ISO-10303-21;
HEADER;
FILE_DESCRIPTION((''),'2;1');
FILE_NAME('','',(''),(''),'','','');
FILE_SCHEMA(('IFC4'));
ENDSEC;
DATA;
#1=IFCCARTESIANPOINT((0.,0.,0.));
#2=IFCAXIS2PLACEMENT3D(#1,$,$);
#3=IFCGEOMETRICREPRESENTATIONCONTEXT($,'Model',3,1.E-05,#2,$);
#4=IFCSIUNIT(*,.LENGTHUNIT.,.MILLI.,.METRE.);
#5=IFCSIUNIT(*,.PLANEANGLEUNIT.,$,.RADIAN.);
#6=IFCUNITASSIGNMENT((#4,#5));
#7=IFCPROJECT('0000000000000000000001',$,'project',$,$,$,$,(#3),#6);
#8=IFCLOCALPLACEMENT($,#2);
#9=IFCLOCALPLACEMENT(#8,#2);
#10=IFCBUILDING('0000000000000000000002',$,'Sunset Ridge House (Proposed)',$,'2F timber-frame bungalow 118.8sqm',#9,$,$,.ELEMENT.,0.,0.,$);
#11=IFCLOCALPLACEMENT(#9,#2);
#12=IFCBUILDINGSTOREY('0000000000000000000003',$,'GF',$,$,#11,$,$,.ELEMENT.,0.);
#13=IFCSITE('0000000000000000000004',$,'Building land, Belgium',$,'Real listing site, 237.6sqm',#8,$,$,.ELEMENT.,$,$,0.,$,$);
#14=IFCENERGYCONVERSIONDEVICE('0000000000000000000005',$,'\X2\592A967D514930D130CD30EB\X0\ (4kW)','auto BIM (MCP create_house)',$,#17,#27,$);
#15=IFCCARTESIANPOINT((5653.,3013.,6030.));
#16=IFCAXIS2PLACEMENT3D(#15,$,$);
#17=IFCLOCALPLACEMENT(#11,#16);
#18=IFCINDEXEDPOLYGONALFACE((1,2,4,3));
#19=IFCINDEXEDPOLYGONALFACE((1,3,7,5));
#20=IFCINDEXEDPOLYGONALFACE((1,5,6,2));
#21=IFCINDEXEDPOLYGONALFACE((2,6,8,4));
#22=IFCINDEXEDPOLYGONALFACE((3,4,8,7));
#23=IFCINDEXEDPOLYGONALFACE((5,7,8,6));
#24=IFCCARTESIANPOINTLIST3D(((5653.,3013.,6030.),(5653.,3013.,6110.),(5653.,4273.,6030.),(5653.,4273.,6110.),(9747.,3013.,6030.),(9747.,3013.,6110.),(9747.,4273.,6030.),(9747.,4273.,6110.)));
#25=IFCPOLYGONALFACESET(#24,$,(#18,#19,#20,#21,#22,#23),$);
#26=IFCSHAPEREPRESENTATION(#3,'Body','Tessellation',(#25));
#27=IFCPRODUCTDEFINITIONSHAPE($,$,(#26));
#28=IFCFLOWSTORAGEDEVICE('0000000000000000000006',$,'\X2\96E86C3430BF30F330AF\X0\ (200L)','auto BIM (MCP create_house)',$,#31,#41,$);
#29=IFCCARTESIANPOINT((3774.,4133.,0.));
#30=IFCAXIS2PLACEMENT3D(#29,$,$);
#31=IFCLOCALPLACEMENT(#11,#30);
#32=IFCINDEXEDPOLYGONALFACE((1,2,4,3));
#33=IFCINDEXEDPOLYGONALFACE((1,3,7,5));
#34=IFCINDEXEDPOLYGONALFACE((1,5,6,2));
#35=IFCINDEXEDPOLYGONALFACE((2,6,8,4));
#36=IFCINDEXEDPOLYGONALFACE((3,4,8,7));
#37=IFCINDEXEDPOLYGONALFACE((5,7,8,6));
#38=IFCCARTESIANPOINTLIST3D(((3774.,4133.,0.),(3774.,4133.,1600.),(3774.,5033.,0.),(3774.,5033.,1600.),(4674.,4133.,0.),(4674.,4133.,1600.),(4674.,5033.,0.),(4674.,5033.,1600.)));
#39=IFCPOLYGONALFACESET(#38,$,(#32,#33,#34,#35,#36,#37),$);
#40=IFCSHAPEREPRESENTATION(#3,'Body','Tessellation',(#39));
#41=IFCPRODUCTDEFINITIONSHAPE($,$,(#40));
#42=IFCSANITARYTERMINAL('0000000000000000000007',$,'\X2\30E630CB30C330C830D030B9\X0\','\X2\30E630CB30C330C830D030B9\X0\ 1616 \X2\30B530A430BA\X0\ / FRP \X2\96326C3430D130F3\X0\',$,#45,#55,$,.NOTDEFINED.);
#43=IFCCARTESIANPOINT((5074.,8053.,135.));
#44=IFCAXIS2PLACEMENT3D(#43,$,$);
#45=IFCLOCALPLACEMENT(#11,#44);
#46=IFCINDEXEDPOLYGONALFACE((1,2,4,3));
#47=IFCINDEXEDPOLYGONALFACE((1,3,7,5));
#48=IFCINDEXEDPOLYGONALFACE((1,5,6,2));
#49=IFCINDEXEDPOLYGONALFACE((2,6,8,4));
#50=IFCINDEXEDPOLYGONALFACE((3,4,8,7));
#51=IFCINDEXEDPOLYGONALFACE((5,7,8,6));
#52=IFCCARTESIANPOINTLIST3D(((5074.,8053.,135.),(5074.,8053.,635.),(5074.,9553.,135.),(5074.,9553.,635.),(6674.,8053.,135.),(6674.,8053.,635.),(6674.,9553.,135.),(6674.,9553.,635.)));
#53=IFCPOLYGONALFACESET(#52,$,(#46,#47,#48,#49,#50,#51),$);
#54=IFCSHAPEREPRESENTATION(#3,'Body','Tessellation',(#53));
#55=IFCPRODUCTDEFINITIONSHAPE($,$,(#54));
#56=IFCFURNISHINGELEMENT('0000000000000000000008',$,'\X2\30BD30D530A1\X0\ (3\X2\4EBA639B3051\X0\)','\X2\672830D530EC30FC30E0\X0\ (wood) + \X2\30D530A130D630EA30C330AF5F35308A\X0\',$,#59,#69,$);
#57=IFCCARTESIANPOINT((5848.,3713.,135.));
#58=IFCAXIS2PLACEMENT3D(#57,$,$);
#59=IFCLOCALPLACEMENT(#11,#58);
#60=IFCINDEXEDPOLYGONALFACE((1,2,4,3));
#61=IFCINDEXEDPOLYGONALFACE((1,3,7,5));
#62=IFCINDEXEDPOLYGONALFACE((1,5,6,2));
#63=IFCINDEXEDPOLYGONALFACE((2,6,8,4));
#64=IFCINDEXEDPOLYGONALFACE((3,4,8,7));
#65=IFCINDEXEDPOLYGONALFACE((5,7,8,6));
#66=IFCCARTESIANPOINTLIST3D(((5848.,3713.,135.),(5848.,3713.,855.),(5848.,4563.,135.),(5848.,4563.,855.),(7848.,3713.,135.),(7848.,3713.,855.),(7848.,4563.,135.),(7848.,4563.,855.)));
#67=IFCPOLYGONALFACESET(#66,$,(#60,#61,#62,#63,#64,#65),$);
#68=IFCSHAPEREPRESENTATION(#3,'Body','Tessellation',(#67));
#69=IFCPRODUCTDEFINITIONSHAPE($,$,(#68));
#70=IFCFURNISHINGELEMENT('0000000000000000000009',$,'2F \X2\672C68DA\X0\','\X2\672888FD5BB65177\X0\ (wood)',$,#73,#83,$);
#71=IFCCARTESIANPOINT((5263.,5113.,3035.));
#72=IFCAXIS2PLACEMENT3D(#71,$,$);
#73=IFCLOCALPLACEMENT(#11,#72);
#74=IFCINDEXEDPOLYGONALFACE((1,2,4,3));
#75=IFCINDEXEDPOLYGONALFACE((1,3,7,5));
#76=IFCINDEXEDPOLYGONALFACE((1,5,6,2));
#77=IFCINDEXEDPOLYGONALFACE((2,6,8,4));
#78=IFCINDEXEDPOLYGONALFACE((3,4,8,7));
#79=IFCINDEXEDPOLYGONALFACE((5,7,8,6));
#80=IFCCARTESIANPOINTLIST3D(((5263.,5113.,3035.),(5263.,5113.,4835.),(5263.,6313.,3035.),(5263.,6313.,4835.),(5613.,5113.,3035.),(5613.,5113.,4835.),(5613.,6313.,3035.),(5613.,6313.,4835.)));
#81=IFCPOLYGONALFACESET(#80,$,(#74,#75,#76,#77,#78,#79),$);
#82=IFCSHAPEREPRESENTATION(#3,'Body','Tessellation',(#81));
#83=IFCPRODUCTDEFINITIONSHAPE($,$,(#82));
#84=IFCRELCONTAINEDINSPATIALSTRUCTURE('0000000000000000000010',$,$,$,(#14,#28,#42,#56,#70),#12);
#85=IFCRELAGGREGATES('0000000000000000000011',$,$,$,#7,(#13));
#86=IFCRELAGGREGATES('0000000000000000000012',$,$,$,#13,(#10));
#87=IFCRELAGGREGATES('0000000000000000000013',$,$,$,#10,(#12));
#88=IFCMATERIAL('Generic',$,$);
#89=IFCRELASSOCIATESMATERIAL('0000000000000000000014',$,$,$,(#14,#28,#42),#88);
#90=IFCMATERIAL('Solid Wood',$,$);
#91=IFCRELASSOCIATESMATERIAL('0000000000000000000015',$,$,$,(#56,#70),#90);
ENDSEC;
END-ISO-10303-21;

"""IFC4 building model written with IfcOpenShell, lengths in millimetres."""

from ifc_helpers import new_model, si_unit, frame, frame_2d, origin, place, context, project, spatial, rectangle, extrude, material, element, save


model = new_model("IFC4")

# Units and contexts
model_context = context("Model", 3, precision=1e-05, world=origin())
ifc_project = project(units=[si_unit("LENGTHUNIT", "METRE", prefix="MILLI"), si_unit("PLANEANGLEUNIT", "RADIAN")], contexts=[model_context])

# Site, building, storey
site_placement = place(None, origin())
site = spatial("IfcSite", under=ifc_project, at=site_placement, Name="Building land, Belgium", ObjectType="Real listing site, 237.6sqm", CompositionType="ELEMENT", RefElevation=0.0)
building_placement = place(site_placement, origin())
building = spatial("IfcBuilding", under=site, at=building_placement, Name="Sunset Ridge House (Proposed)", ObjectType="2F timber-frame bungalow 118.8sqm", CompositionType="ELEMENT", ElevationOfRefHeight=0.0, ElevationOfTerrain=0.0)
storey_placement = place(building_placement, origin())
storey = spatial("IfcBuildingStorey", under=building, at=storey_placement, Name="GF", CompositionType="ELEMENT", Elevation=0.0)

# Shared definitions
ifc_material_1 = material(Name="Solid Wood")

# Energy conversion device
ifc_material_2 = material(Name="Generic")
energy_conversion_device_placement = place(storey_placement, frame((5653.0, 3013.0, 6030.0)))
element("IfcEnergyConversionDevice", 1, at=energy_conversion_device_placement, inside=storey, material=ifc_material_2, Name="太陽光パネル (4kW)", Description="auto BIM (MCP create_house)", context=model_context, shape_type="SweptSolid", body=[
    extrude(rectangle(XDim=4094.0, YDim=1260.0, at=frame_2d((2047.0, 630.0))), frame((5653.0, 3013.0, 6030.0)), (0.0, 0.0, 1.0), 80.0),
])

# Flow storage device
flow_storage_device_placement = place(storey_placement, frame((3774.0, 4133.0, 0.0)))
element("IfcFlowStorageDevice", 2, at=flow_storage_device_placement, inside=storey, material=ifc_material_2, Name="雨水タンク (200L)", Description="auto BIM (MCP create_house)", context=model_context, shape_type="SweptSolid", body=[
    extrude(rectangle(XDim=900.0, YDim=900.0, at=frame_2d((450.0, 450.0))), frame((3774.0, 4133.0, 0.0)), (0.0, 0.0, 1.0), 1600.0),
])

# Sanitary terminal
sanitary_terminal_placement = place(storey_placement, frame((5074.0, 8053.0, 135.0)))
element("IfcSanitaryTerminal", 3, at=sanitary_terminal_placement, inside=storey, material=ifc_material_2, Name="ユニットバス", Description="ユニットバス 1616 サイズ / FRP 防水パン", PredefinedType="NOTDEFINED", context=model_context, shape_type="SweptSolid", body=[
    extrude(rectangle(XDim=1600.0, YDim=1500.0, at=frame_2d((800.0, 750.0))), frame((5074.0, 8053.0, 135.0)), (0.0, 0.0, 1.0), 500.0),
])

# Furnishing elements
furnishing_1_placement = place(storey_placement, frame((5848.0, 3713.0, 135.0)))
element("IfcFurnishingElement", 4, at=furnishing_1_placement, inside=storey, material=ifc_material_1, Name="ソファ (3人掛け)", Description="木フレーム (wood) + ファブリック張り", context=model_context, shape_type="SweptSolid", body=[
    extrude(rectangle(XDim=2000.0, YDim=850.0, at=frame_2d((1000.0, 425.0))), frame((5848.0, 3713.0, 135.0)), (0.0, 0.0, 1.0), 720.0),
])
furnishing_2_placement = place(storey_placement, frame((5263.0, 5113.0, 3035.0)))
element("IfcFurnishingElement", 5, at=furnishing_2_placement, inside=storey, material=ifc_material_1, Name="2F 本棚", Description="木製家具 (wood)", context=model_context, shape_type="SweptSolid", body=[
    extrude(rectangle(XDim=350.0, YDim=1200.0, at=frame_2d((175.0, 600.0))), frame((5263.0, 5113.0, 3035.0)), (0.0, 0.0, 1.0), 1800.0),
])

save(model, "model.ifc")
